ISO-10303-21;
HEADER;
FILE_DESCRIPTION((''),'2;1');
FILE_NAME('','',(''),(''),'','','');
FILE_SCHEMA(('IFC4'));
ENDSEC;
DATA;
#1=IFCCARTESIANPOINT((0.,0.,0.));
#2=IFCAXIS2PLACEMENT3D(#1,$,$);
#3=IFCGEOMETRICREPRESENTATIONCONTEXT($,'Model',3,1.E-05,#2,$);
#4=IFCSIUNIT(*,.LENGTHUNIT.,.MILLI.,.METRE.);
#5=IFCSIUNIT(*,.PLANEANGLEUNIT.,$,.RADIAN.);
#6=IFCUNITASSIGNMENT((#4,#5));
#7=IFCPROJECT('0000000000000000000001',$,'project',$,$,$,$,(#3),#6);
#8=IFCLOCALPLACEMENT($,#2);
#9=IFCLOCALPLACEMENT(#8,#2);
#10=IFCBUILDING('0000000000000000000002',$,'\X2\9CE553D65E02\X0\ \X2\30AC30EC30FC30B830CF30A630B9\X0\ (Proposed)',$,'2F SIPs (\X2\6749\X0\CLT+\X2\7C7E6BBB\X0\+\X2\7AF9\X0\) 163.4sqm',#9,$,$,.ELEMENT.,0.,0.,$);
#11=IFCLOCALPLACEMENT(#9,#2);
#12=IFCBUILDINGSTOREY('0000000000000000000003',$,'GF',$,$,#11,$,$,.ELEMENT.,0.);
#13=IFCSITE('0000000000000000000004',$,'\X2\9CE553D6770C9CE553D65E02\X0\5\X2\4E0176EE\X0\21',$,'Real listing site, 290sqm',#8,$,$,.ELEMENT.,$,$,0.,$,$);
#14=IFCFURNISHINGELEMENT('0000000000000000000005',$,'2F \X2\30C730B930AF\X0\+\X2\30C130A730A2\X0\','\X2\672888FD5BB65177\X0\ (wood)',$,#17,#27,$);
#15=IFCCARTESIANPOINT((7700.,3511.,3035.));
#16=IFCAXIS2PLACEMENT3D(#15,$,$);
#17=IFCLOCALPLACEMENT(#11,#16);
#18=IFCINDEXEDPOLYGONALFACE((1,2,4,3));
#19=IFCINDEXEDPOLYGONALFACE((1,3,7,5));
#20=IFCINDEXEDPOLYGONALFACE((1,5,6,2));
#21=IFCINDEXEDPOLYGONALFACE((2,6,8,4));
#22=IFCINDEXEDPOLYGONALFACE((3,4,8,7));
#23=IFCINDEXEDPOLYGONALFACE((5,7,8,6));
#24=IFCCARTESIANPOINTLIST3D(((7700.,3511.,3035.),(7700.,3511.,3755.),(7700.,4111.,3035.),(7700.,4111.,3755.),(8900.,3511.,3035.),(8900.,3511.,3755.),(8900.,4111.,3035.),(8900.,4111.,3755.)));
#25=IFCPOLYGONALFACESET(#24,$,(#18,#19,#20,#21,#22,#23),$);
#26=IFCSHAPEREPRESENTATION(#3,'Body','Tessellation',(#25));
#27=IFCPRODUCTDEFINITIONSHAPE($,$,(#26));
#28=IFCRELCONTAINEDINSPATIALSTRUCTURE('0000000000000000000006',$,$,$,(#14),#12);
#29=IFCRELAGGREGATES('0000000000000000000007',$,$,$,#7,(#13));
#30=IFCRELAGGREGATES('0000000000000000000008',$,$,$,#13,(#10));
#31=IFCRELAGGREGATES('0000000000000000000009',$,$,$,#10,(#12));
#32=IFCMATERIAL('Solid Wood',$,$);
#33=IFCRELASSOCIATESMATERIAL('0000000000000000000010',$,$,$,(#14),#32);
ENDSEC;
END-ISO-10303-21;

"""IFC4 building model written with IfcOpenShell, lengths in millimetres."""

from ifc_helpers import new_model, si_unit, frame, frame_2d, origin, place, context, project, spatial, rectangle, extrude, material, element, save


model = new_model("IFC4")

# Units and contexts
model_context = context("Model", 3, precision=1e-05, world=origin())
ifc_project = project(units=[si_unit("LENGTHUNIT", "METRE", prefix="MILLI"), si_unit("PLANEANGLEUNIT", "RADIAN")], contexts=[model_context])

# Site, building, storey
site_placement = place(None, origin())
site = spatial("IfcSite", under=ifc_project, at=site_placement, Name="鳥取県鳥取市5丁目21", ObjectType="Real listing site, 290sqm", CompositionType="ELEMENT", RefElevation=0.0)
building_placement = place(site_placement, origin())
building = spatial("IfcBuilding", under=site, at=building_placement, Name="鳥取市 ガレージハウス (Proposed)", ObjectType="2F SIPs (杉CLT+籾殻+竹) 163.4sqm", CompositionType="ELEMENT", ElevationOfRefHeight=0.0, ElevationOfTerrain=0.0)
storey_placement = place(building_placement, origin())
storey = spatial("IfcBuildingStorey", under=building, at=storey_placement, Name="GF", CompositionType="ELEMENT", Elevation=0.0)

# Shared definitions
ifc_material_1 = material(Name="Solid Wood")

# Furnishing element
furnishing_1_placement = place(storey_placement, frame((7700.0, 3511.0, 3035.0)))
element("IfcFurnishingElement", 1, at=furnishing_1_placement, inside=storey, material=ifc_material_1, Name="2F デスク+チェア", Description="木製家具 (wood)", context=model_context, shape_type="SweptSolid", body=[
    extrude(rectangle(XDim=1200.0, YDim=600.0, at=frame_2d((600.0, 300.0))), frame((7700.0, 3511.0, 3035.0)), (0.0, 0.0, 1.0), 720.0),
])

save(model, "model.ifc")
